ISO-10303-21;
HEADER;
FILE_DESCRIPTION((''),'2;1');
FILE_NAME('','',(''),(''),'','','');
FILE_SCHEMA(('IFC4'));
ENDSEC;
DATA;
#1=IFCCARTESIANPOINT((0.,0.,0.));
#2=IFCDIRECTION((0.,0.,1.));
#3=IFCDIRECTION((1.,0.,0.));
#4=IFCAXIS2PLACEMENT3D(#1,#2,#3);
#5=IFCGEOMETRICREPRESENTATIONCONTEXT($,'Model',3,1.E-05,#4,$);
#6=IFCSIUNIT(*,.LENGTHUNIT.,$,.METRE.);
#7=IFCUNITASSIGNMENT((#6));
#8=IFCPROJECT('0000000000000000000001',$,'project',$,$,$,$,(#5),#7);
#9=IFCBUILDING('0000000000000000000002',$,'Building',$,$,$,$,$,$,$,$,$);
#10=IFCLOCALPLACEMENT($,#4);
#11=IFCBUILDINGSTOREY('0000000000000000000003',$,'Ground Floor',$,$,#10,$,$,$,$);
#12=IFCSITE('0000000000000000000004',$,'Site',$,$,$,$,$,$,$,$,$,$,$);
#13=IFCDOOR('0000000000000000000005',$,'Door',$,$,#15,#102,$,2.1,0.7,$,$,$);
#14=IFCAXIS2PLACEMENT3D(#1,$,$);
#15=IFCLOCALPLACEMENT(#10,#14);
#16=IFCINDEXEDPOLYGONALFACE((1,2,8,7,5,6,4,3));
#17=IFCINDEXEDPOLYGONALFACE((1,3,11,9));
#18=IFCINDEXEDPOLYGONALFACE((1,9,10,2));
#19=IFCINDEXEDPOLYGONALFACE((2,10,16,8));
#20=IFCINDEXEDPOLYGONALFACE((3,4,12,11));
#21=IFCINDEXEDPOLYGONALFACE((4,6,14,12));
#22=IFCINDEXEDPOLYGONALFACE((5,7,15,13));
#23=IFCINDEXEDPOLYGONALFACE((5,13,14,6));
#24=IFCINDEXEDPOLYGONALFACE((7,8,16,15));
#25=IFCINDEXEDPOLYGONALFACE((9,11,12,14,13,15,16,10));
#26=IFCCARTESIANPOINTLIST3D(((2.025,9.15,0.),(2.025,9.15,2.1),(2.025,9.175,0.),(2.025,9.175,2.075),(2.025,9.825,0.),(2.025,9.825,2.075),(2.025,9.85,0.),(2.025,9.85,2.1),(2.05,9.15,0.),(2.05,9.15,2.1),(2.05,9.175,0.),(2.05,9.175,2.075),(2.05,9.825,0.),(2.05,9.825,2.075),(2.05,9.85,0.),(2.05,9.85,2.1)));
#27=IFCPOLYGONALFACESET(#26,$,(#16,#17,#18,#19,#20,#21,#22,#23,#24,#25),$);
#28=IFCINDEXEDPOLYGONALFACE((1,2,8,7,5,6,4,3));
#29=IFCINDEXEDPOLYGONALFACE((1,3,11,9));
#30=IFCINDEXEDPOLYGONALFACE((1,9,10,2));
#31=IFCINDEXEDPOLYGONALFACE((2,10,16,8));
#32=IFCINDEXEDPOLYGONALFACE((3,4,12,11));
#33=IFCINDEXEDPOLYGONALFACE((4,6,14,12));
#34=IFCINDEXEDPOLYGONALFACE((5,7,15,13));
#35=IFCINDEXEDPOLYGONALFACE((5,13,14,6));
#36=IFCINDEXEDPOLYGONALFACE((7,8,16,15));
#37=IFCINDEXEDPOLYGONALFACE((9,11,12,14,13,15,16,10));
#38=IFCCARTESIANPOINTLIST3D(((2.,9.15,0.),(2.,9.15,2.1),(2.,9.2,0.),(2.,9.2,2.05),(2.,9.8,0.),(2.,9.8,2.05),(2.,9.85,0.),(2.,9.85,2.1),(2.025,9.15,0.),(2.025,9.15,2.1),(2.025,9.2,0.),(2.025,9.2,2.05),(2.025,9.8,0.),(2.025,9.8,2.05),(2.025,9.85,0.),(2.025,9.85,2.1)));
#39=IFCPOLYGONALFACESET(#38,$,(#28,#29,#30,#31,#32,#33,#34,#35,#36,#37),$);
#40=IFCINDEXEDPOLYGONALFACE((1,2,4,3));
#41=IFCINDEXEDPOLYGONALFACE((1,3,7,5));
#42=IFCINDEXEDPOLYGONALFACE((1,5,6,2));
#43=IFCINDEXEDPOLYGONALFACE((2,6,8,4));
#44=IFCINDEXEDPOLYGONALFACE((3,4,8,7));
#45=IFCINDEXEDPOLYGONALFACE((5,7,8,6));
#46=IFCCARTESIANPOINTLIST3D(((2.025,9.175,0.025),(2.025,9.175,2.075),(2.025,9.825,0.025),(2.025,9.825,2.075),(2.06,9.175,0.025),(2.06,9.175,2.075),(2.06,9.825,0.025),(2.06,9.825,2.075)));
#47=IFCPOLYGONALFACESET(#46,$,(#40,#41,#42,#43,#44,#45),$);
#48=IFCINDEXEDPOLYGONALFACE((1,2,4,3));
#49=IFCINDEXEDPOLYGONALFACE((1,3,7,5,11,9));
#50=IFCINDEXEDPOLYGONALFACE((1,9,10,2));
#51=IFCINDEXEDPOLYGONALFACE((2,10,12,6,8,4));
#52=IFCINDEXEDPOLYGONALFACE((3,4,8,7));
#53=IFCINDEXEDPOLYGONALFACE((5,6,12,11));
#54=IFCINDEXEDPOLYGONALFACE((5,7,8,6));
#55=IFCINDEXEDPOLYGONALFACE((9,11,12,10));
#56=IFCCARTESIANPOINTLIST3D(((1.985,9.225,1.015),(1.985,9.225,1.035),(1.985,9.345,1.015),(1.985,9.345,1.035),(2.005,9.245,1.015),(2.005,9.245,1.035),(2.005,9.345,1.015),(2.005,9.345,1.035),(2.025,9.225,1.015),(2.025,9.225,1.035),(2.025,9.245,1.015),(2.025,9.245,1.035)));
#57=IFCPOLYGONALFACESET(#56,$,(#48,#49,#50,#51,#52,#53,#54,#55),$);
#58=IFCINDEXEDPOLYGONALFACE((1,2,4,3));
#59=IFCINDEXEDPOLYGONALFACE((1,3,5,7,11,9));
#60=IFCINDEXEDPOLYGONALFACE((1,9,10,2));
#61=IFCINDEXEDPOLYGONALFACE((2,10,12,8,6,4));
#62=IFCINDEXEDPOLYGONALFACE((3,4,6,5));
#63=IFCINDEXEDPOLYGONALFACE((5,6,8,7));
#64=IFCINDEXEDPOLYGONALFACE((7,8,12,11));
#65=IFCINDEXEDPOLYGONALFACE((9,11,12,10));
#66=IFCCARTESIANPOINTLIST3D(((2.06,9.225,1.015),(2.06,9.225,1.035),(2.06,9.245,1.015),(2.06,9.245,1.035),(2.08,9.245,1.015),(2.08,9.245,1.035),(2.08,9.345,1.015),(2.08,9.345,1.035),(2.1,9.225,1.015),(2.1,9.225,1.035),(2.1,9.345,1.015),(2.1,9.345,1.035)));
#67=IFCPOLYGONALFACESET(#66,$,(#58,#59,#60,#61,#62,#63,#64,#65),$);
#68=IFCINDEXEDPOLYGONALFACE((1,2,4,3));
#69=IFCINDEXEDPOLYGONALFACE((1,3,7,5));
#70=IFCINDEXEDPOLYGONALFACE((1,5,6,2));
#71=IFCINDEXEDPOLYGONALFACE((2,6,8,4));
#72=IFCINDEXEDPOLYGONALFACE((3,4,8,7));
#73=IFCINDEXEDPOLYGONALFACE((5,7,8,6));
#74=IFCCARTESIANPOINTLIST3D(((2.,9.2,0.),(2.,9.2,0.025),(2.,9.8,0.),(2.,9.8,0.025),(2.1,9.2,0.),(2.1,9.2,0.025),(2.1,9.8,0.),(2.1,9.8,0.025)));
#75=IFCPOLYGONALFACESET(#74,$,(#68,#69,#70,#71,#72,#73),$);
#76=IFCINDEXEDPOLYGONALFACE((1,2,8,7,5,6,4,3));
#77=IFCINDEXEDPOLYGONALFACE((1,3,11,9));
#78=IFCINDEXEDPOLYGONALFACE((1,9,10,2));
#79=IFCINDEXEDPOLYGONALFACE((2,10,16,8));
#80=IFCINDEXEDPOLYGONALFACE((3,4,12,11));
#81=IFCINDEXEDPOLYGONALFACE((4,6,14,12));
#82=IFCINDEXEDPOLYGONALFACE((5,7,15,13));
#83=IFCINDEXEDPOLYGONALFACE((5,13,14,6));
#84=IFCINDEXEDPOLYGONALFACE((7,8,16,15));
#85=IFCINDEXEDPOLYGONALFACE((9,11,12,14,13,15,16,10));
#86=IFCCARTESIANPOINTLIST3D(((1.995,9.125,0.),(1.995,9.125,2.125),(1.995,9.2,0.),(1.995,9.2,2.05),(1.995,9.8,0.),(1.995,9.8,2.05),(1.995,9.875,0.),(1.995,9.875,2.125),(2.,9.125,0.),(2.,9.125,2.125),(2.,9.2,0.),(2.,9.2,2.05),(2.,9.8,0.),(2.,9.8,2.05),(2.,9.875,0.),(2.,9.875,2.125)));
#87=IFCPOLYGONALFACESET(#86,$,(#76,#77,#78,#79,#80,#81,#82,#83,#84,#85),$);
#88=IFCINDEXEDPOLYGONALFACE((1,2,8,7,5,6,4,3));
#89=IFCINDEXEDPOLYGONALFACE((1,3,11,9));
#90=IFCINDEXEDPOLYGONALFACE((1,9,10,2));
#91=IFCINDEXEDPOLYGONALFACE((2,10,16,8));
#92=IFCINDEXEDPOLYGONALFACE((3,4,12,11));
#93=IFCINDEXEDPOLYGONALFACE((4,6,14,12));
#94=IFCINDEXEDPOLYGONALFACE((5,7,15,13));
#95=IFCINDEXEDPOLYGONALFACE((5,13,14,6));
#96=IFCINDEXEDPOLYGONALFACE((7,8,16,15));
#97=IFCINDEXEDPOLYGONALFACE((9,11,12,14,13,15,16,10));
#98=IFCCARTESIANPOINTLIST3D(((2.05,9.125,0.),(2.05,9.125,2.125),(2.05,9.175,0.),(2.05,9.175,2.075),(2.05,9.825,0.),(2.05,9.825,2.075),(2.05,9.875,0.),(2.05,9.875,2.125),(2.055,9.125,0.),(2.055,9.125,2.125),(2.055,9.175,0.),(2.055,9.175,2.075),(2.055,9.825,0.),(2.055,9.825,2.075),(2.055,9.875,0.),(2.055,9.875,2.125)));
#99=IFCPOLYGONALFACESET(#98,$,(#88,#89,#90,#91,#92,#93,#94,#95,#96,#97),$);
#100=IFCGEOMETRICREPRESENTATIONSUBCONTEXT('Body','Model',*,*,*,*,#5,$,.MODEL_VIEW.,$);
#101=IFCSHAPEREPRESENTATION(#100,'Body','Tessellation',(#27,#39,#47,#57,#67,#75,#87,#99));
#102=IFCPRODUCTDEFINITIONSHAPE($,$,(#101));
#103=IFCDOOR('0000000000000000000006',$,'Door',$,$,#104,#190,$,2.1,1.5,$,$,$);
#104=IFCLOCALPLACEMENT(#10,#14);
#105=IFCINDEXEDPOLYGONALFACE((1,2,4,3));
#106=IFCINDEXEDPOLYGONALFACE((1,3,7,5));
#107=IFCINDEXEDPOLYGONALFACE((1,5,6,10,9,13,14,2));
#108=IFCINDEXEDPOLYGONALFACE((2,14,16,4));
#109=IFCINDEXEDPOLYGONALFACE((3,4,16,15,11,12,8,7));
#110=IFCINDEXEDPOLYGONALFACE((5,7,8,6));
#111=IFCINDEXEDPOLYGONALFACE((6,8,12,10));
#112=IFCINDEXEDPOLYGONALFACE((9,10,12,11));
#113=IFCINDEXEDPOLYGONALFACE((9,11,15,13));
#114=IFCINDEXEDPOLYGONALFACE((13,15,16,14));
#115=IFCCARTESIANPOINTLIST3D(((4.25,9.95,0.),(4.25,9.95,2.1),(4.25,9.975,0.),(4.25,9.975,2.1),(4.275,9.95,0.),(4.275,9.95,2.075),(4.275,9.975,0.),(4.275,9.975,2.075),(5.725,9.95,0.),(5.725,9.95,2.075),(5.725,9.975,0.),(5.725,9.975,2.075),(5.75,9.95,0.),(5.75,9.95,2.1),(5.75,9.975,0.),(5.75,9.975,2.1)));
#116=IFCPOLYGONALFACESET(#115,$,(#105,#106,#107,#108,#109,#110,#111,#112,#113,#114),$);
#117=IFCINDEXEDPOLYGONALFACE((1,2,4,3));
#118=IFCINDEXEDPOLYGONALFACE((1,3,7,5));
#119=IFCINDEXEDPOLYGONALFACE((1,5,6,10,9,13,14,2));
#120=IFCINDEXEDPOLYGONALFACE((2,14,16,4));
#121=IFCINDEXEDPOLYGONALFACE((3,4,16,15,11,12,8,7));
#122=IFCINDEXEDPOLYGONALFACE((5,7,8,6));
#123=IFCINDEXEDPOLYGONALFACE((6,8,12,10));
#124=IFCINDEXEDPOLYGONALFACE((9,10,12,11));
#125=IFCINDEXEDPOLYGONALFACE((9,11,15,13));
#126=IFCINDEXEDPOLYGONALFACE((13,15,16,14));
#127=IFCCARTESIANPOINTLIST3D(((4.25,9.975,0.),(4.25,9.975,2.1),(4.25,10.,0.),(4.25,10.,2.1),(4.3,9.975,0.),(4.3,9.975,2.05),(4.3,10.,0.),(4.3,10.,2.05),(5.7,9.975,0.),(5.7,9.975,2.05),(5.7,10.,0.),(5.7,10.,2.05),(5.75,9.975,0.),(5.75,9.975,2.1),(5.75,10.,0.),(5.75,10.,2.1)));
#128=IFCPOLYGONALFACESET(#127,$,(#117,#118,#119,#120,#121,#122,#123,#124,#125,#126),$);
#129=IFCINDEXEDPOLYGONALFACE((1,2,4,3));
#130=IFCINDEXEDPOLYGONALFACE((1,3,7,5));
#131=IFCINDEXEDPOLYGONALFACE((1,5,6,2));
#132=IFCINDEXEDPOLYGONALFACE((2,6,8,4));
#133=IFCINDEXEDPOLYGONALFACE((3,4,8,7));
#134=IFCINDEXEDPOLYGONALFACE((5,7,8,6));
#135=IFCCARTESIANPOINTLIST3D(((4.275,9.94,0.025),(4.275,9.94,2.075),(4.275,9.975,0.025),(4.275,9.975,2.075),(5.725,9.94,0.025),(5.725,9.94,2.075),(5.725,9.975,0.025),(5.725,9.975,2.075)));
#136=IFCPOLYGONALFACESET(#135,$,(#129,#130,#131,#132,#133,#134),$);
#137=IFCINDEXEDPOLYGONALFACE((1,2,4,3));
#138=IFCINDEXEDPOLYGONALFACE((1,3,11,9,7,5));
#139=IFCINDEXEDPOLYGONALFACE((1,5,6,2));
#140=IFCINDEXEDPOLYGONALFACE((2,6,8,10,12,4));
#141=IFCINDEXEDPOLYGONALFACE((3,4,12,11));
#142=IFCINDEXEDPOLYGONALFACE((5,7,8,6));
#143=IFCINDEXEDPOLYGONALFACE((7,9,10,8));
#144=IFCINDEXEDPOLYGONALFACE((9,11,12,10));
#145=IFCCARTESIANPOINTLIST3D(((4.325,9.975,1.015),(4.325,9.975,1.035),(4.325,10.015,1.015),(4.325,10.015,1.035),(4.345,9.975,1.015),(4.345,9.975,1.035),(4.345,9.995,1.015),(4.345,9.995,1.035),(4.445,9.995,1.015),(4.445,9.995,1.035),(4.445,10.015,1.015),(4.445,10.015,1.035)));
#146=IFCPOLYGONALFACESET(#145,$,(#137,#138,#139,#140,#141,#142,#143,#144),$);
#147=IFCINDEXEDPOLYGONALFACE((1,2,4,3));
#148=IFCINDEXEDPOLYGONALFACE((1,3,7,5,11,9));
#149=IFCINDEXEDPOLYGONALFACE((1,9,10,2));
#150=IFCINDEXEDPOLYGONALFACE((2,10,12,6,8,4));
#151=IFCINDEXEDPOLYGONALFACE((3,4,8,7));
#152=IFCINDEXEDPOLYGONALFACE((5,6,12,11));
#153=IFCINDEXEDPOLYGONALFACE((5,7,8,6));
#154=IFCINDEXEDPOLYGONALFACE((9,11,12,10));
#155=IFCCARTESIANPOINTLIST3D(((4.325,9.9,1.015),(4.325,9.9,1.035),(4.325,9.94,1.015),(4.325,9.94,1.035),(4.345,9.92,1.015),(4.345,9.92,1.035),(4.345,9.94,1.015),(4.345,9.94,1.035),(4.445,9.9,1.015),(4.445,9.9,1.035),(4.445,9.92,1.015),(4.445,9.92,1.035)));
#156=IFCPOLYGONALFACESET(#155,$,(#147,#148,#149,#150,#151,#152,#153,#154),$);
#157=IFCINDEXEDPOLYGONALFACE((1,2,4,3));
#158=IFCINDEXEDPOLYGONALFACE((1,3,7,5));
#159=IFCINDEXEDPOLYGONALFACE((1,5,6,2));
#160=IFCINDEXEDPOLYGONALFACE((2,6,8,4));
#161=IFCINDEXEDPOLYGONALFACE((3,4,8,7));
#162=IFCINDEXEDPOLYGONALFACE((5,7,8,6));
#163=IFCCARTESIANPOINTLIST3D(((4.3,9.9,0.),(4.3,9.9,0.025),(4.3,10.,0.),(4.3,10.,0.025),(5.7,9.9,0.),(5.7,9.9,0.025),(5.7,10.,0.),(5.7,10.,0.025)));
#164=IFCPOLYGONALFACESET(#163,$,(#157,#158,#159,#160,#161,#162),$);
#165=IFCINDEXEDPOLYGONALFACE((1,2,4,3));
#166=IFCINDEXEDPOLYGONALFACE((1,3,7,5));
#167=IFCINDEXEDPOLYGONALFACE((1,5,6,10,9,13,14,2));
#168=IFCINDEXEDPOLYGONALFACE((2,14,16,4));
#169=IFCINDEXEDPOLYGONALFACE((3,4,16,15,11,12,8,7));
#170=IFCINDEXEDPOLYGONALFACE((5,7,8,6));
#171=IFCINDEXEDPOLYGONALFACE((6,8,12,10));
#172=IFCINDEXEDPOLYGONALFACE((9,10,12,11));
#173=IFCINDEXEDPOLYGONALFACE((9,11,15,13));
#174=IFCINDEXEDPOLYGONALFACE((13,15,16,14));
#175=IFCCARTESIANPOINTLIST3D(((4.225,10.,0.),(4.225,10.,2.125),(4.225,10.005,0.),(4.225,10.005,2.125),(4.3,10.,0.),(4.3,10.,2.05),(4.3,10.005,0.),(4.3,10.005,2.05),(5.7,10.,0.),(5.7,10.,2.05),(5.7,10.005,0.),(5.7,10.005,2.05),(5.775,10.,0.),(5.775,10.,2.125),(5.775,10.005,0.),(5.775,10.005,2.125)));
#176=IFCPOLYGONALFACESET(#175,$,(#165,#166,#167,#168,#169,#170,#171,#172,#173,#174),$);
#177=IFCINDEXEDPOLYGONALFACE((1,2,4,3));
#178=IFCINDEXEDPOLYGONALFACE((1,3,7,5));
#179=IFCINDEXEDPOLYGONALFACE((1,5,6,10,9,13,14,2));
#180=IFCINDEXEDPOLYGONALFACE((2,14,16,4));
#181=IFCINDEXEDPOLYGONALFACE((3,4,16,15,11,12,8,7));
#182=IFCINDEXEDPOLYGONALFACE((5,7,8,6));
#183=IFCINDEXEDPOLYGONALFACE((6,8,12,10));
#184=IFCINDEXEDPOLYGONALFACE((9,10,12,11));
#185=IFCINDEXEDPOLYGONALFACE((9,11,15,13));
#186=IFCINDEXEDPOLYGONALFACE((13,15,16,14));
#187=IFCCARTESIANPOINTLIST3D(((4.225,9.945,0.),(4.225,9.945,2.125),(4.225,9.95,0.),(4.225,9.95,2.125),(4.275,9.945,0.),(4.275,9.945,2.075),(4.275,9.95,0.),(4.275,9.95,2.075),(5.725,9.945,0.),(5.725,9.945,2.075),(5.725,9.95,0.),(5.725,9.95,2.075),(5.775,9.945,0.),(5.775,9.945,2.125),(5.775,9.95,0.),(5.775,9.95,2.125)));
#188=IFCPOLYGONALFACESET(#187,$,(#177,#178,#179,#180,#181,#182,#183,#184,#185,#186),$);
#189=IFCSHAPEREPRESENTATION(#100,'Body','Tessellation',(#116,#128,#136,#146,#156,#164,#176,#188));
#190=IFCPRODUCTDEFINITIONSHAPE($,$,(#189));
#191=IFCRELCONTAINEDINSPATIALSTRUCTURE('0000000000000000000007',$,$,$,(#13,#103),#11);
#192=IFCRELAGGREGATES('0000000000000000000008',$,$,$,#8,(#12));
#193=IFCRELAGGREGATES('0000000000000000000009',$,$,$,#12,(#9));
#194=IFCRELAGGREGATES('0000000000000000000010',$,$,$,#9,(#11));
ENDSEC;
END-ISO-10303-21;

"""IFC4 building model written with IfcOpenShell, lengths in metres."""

from ifc_helpers import new_model, si_unit, frame, origin_with_axes, place, context, subcontext, project, spatial, line, indexed_curve, outline, extrude, element, save


model = new_model("IFC4")

# Units and contexts
model_context = context("Model", 3, precision=1e-05, world=origin_with_axes())
body_context = subcontext(model_context, "Body", "Model", "MODEL_VIEW")
ifc_project = project(units=[si_unit("LENGTHUNIT", "METRE")], contexts=[model_context])

# Site, building, storey
site = spatial("IfcSite", under=ifc_project, Name="Site")
building = spatial("IfcBuilding", under=site, Name="Building")
storey_placement = place(None, origin_with_axes())
storey = spatial("IfcBuildingStorey", under=building, at=storey_placement, Name="Ground Floor")

# Doors
door_1_placement = place(storey_placement, frame((2.0, 9.85, 0.0), z_axis=(0.0, 0.0, 1.0), x_axis=(0.0, -1.0, 0.0)))
element("IfcDoor", 1, at=door_1_placement, inside=storey, Name="Door", OverallHeight=2.1, OverallWidth=0.7, context=body_context, shape_type="SweptSolid", body=[
    extrude(outline(indexed_curve([(0.0, 0.0), (0.0, 2.1), (0.7, 2.1), (0.7, 0.0), (0.675, 0.0), (0.675, 2.075), (0.025, 2.075), (0.025, 0.0)], segments=[line(1, 2, 3, 4, 5, 6, 7, 8, 1)])), frame((0.0, 0.025, 0.0), z_axis=(0.0, -1.0, 0.0), x_axis=(1.0, 0.0, 0.0)), (0.0, 0.0, -1.0), 0.025),
    extrude(outline(indexed_curve([(0.0, 0.0), (0.0, 2.1), (0.7, 2.1), (0.7, 0.0), (0.65, 0.0), (0.65, 2.05), (0.05, 2.05), (0.05, 0.0)], segments=[line(1, 2, 3, 4, 5, 6, 7, 8, 1)])), frame((0.0, 0.0, 0.0), z_axis=(0.0, -1.0, 0.0), x_axis=(1.0, 0.0, 0.0)), (0.0, 0.0, -1.0), 0.025),
    extrude(outline(indexed_curve([(0.0, 0.0), (0.65, 0.0), (0.65, 0.035), (0.0, 0.035)], segments=[line(1, 2, 3, 4, 1)])), frame((0.025, 0.025, 0.025), z_axis=(0.0, 0.0, 1.0), x_axis=(1.0, 0.0, 0.0)), (0.0, 0.0, 1.0), 2.05),
    extrude(outline(indexed_curve([(0.0, 0.0), (0.0, -0.04), (-0.12, -0.04), (-0.12, -0.02), (-0.02, -0.02), (-0.02, 0.0)], segments=[line(1, 2, 3, 4, 5, 6, 1)])), frame((0.625, 0.025, 1.015), z_axis=(0.0, 0.0, 1.0), x_axis=(1.0, 0.0, 0.0)), (0.0, 0.0, 1.0), 0.02),
    extrude(outline(indexed_curve([(0.0, 0.0), (0.0, 0.04), (-0.12, 0.04), (-0.12, 0.02), (-0.02, 0.02), (-0.02, 0.0)], segments=[line(1, 2, 3, 4, 5, 6, 1)])), frame((0.625, 0.06, 1.015), z_axis=(0.0, 0.0, 1.0), x_axis=(1.0, 0.0, 0.0)), (0.0, 0.0, 1.0), 0.02),
    extrude(outline(indexed_curve([(0.0, 0.0), (0.6, 0.0), (0.6, 0.1), (0.0, 0.1)], segments=[line(1, 2, 3, 4, 1)])), frame((0.05, 0.0, 0.0), z_axis=(0.0, 0.0, 1.0), x_axis=(1.0, 0.0, 0.0)), (0.0, 0.0, 1.0), 0.025),
    extrude(outline(indexed_curve([(0.0, 0.0), (0.0, 2.125), (0.75, 2.125), (0.75, 0.0), (0.675, 0.0), (0.675, 2.05), (0.075, 2.05), (0.075, 0.0)], segments=[line(1, 2, 3, 4, 5, 6, 7, 8, 1)])), frame((-0.025, -0.005, 0.0), z_axis=(0.0, -1.0, 0.0), x_axis=(1.0, 0.0, 0.0)), (0.0, 0.0, -1.0), 0.005),
    extrude(outline(indexed_curve([(0.0, 0.0), (0.0, 2.125), (0.75, 2.125), (0.75, 0.0), (0.7, 0.0), (0.7, 2.075), (0.05, 2.075), (0.05, 0.0)], segments=[line(1, 2, 3, 4, 5, 6, 7, 8, 1)])), frame((-0.025, 0.05, 0.0), z_axis=(0.0, -1.0, 0.0), x_axis=(1.0, 0.0, 0.0)), (0.0, 0.0, -1.0), 0.005),
])
door_2_placement = place(storey_placement, frame((5.75, 10.0, 0.0), z_axis=(0.0, 0.0, 1.0), x_axis=(-1.0, 0.0, 0.0)))
element("IfcDoor", 2, at=door_2_placement, inside=storey, Name="Door", OverallHeight=2.1, OverallWidth=1.5, context=body_context, shape_type="SweptSolid", body=[
    extrude(outline(indexed_curve([(0.0, 0.0), (0.0, 2.1), (1.5, 2.1), (1.5, 0.0), (1.475, 0.0), (1.475, 2.075), (0.025, 2.075), (0.025, 0.0)], segments=[line(1, 2, 3, 4, 5, 6, 7, 8, 1)])), frame((0.0, 0.025, 0.0), z_axis=(0.0, -1.0, 0.0), x_axis=(1.0, 0.0, 0.0)), (0.0, 0.0, -1.0), 0.025),
    extrude(outline(indexed_curve([(0.0, 0.0), (0.0, 2.1), (1.5, 2.1), (1.5, 0.0), (1.45, 0.0), (1.45, 2.05), (0.05, 2.05), (0.05, 0.0)], segments=[line(1, 2, 3, 4, 5, 6, 7, 8, 1)])), frame((0.0, 0.0, 0.0), z_axis=(0.0, -1.0, 0.0), x_axis=(1.0, 0.0, 0.0)), (0.0, 0.0, -1.0), 0.025),
    extrude(outline(indexed_curve([(0.0, 0.0), (1.45, 0.0), (1.45, 0.035), (0.0, 0.035)], segments=[line(1, 2, 3, 4, 1)])), frame((0.025, 0.025, 0.025), z_axis=(0.0, 0.0, 1.0), x_axis=(1.0, 0.0, 0.0)), (0.0, 0.0, 1.0), 2.05),
    extrude(outline(indexed_curve([(0.0, 0.0), (0.0, -0.04), (-0.12, -0.04), (-0.12, -0.02), (-0.02, -0.02), (-0.02, 0.0)], segments=[line(1, 2, 3, 4, 5, 6, 1)])), frame((1.425, 0.025, 1.015), z_axis=(0.0, 0.0, 1.0), x_axis=(1.0, 0.0, 0.0)), (0.0, 0.0, 1.0), 0.02),
    extrude(outline(indexed_curve([(0.0, 0.0), (0.0, 0.04), (-0.12, 0.04), (-0.12, 0.02), (-0.02, 0.02), (-0.02, 0.0)], segments=[line(1, 2, 3, 4, 5, 6, 1)])), frame((1.425, 0.06, 1.015), z_axis=(0.0, 0.0, 1.0), x_axis=(1.0, 0.0, 0.0)), (0.0, 0.0, 1.0), 0.02),
    extrude(outline(indexed_curve([(0.0, 0.0), (1.4, 0.0), (1.4, 0.1), (0.0, 0.1)], segments=[line(1, 2, 3, 4, 1)])), frame((0.05, 0.0, 0.0), z_axis=(0.0, 0.0, 1.0), x_axis=(1.0, 0.0, 0.0)), (0.0, 0.0, 1.0), 0.025),
    extrude(outline(indexed_curve([(0.0, 0.0), (0.0, 2.125), (1.55, 2.125), (1.55, 0.0), (1.475, 0.0), (1.475, 2.05), (0.075, 2.05), (0.075, 0.0)], segments=[line(1, 2, 3, 4, 5, 6, 7, 8, 1)])), frame((-0.025, -0.005, 0.0), z_axis=(0.0, -1.0, 0.0), x_axis=(1.0, 0.0, 0.0)), (0.0, 0.0, -1.0), 0.005),
    extrude(outline(indexed_curve([(0.0, 0.0), (0.0, 2.125), (1.55, 2.125), (1.55, 0.0), (1.5, 0.0), (1.5, 2.075), (0.05, 2.075), (0.05, 0.0)], segments=[line(1, 2, 3, 4, 5, 6, 7, 8, 1)])), frame((-0.025, 0.05, 0.0), z_axis=(0.0, -1.0, 0.0), x_axis=(1.0, 0.0, 0.0)), (0.0, 0.0, -1.0), 0.005),
])

save(model, "model.ifc")
